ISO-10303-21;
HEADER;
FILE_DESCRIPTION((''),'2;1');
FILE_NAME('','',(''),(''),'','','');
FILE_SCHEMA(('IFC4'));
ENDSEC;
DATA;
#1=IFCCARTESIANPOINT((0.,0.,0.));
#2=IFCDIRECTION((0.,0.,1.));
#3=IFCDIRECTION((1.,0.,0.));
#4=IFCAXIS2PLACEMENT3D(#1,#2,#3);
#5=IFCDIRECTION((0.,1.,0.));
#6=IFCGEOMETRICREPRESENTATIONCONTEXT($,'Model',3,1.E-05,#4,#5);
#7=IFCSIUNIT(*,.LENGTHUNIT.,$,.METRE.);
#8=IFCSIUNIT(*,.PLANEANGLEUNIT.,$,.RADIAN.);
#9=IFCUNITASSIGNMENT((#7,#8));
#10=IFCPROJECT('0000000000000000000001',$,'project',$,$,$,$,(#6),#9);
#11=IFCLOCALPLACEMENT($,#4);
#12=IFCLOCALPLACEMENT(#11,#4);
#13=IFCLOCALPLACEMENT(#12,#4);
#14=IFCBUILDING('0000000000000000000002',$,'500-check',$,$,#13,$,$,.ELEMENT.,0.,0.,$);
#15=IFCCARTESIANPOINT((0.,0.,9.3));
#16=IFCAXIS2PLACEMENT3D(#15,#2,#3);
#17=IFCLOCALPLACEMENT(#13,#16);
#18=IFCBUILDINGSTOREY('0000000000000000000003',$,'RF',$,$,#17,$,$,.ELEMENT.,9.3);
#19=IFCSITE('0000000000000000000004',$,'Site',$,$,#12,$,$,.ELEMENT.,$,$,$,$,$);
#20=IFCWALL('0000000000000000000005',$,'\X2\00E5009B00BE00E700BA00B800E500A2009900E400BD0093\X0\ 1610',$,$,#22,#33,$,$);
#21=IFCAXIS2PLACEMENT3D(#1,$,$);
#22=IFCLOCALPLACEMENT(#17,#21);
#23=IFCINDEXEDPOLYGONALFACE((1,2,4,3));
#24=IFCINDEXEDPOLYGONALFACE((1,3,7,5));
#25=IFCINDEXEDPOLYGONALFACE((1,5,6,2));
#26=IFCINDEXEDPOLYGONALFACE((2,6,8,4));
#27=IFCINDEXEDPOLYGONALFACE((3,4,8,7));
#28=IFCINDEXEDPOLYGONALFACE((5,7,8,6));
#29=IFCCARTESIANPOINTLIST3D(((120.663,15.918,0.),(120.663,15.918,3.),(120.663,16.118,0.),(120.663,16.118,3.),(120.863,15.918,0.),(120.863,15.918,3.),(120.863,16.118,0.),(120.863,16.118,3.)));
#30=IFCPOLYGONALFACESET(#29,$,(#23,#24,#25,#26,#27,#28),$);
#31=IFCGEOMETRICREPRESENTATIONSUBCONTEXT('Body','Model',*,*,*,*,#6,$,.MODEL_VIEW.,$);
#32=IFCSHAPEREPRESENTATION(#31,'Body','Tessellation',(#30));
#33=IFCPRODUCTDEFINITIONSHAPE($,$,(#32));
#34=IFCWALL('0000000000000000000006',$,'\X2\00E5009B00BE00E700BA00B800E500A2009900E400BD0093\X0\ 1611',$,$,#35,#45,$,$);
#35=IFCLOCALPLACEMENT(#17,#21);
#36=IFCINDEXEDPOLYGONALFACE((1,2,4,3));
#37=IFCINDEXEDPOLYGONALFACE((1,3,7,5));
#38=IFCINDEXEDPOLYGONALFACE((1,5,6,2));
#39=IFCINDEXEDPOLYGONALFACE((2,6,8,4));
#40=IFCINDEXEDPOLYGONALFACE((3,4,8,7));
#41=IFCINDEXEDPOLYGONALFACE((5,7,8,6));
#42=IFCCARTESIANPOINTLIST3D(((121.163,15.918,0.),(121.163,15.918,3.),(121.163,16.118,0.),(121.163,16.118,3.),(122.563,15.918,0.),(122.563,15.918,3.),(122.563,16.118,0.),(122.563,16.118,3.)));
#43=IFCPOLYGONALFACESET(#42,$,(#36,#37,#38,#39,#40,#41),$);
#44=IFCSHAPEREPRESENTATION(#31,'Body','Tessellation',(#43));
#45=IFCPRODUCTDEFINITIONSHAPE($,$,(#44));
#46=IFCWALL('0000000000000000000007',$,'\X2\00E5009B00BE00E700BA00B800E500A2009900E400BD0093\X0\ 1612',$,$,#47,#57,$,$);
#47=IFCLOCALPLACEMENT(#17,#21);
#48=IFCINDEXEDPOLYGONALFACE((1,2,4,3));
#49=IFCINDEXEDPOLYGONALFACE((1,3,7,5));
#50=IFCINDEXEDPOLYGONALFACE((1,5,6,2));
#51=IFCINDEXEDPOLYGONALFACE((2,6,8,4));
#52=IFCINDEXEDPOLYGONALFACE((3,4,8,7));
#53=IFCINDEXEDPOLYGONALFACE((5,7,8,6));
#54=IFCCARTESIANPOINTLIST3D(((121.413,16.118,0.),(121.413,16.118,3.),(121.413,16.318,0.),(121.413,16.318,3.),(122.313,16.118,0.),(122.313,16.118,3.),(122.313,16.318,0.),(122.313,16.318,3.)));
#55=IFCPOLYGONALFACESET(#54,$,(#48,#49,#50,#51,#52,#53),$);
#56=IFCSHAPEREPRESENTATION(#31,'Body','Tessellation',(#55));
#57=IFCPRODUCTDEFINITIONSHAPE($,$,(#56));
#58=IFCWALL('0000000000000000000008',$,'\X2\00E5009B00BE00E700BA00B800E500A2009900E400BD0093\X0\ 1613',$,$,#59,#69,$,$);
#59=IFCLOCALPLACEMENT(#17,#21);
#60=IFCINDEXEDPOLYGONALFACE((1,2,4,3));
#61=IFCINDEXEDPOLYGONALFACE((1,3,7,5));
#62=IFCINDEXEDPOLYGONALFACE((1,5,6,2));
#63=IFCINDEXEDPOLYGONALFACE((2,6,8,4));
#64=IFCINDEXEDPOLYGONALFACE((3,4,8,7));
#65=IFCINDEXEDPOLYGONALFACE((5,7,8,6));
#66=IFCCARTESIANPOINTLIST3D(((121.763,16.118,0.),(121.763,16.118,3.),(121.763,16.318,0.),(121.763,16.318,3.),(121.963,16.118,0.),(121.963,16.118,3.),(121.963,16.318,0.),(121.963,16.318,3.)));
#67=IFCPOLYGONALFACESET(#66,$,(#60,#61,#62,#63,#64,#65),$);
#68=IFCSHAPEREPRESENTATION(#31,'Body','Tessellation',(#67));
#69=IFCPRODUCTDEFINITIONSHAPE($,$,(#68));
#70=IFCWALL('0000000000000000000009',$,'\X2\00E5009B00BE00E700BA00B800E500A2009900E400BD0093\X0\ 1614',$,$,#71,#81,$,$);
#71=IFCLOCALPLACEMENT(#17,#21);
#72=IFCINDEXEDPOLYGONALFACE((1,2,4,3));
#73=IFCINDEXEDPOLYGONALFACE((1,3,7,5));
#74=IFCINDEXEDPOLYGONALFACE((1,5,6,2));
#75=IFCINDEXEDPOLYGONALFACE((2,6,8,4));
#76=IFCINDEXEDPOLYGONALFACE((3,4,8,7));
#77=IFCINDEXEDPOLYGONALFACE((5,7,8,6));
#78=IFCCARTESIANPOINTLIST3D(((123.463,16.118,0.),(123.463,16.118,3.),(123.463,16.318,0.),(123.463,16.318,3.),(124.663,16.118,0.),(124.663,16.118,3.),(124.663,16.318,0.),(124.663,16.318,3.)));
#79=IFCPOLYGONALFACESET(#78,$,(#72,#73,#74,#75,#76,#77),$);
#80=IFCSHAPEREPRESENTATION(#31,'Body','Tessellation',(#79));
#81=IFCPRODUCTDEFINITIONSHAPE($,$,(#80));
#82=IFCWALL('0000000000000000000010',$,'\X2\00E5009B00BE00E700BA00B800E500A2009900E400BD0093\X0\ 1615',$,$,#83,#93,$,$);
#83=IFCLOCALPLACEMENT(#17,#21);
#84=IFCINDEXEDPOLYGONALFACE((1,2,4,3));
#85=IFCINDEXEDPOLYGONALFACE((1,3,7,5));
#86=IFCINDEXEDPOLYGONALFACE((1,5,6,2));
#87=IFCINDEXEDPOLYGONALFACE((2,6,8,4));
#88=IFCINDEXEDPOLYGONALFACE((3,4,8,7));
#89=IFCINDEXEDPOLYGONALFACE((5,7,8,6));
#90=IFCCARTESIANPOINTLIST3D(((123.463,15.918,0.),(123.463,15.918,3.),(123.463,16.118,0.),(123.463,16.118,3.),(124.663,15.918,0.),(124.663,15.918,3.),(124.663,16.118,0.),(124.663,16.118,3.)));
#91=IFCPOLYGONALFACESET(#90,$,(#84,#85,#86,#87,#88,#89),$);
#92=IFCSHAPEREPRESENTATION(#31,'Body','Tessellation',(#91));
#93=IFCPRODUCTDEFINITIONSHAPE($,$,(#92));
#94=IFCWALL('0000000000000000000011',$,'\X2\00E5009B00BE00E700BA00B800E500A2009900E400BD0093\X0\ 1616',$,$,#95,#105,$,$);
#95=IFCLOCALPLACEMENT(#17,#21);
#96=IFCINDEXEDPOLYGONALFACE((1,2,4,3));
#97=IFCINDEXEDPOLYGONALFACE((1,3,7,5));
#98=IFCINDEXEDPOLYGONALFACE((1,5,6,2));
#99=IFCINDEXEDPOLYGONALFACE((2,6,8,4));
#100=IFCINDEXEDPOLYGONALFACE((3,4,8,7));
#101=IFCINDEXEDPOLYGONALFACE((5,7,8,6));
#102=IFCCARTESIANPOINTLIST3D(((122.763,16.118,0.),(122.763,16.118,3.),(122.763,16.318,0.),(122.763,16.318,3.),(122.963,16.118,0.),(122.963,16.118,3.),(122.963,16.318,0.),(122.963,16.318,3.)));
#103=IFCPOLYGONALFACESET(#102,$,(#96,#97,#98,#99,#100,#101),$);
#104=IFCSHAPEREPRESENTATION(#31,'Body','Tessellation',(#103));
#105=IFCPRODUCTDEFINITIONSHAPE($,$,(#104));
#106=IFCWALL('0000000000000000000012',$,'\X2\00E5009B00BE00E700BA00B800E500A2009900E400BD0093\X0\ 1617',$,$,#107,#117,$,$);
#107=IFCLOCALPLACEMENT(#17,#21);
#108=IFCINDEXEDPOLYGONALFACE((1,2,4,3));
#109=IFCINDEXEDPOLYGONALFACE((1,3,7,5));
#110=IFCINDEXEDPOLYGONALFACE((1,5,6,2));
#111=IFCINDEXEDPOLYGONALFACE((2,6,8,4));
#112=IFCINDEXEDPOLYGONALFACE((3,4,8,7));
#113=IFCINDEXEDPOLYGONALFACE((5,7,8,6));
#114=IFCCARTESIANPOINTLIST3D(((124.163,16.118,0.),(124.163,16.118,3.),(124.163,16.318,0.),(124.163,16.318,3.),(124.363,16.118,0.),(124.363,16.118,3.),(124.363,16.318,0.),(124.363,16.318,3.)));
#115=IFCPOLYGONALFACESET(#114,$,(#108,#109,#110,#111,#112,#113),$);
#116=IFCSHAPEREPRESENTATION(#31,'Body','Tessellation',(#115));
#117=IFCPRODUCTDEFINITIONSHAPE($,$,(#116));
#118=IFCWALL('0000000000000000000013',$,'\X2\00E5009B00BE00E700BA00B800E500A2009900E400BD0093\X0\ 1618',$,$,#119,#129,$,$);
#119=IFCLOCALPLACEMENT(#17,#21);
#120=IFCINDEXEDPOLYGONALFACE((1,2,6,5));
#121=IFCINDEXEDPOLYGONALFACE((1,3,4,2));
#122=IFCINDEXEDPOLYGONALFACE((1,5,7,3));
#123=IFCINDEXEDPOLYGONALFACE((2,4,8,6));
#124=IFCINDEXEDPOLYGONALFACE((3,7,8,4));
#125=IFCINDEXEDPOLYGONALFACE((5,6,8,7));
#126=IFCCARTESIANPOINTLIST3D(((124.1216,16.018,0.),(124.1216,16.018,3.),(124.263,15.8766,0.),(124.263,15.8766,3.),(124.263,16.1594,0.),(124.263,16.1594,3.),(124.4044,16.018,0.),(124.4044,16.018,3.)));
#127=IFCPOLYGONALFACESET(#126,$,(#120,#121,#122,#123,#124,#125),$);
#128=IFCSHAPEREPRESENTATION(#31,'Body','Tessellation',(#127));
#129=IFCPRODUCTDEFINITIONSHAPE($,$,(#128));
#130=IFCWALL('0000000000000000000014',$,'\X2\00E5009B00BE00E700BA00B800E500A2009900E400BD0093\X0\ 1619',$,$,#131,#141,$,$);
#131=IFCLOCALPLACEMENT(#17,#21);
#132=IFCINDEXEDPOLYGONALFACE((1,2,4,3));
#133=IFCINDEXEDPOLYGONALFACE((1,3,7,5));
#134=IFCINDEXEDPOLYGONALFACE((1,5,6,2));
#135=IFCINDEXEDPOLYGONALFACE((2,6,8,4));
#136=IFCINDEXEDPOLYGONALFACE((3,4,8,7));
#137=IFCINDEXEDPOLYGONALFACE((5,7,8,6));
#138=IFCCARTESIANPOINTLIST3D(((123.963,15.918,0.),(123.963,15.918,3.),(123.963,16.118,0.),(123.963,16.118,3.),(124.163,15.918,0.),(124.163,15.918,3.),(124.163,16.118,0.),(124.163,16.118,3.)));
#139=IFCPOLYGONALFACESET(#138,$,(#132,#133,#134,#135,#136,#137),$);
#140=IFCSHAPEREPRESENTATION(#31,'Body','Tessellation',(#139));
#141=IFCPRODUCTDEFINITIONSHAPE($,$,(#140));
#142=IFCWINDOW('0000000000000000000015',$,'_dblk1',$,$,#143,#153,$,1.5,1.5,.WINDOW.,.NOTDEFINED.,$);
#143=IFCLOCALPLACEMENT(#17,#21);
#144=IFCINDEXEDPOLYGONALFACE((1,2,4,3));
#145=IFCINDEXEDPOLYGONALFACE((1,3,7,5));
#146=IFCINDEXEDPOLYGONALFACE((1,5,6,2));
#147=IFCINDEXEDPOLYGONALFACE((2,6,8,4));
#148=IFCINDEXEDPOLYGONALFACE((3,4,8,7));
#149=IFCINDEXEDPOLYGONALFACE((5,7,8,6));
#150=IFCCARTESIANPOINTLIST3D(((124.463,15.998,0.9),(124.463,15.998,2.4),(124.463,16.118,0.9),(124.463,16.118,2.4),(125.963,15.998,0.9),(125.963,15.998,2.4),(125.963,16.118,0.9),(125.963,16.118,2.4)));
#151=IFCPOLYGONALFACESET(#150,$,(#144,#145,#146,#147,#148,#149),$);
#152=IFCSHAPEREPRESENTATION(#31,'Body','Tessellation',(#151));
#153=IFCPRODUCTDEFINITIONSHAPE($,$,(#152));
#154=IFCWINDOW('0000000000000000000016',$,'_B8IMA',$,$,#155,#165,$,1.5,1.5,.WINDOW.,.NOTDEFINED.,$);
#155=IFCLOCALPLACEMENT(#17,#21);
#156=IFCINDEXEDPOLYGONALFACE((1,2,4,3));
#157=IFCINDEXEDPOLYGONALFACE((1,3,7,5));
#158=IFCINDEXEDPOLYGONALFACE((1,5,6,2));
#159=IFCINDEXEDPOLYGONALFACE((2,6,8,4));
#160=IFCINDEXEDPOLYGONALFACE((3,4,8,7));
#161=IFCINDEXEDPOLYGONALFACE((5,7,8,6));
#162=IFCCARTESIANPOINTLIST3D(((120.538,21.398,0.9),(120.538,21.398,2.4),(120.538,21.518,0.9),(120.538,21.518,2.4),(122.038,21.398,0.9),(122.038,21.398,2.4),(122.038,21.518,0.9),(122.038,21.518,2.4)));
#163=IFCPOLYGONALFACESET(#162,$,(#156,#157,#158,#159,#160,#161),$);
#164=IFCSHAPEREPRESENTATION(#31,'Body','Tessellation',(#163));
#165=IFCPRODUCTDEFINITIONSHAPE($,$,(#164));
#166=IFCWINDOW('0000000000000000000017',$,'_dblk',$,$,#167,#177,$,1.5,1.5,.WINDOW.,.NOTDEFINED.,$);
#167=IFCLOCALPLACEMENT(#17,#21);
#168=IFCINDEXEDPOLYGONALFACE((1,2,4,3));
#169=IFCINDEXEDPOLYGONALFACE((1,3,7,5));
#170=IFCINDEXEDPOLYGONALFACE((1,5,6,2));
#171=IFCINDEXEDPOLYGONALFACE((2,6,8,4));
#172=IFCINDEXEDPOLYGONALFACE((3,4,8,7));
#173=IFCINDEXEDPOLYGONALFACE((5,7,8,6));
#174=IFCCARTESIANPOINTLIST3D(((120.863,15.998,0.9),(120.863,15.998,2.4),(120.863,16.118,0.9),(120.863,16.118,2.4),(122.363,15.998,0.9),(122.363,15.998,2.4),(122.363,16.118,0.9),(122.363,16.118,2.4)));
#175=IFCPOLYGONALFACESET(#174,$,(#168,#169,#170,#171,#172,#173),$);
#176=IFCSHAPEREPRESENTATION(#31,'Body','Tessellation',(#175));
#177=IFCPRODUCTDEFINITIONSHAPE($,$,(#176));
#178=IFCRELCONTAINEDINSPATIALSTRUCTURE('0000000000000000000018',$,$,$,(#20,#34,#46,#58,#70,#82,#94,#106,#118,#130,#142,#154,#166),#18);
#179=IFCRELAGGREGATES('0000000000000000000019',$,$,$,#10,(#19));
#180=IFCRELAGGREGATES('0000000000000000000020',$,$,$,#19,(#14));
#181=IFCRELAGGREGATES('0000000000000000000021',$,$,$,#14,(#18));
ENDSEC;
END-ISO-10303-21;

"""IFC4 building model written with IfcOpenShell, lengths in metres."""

from ifc_helpers import new_model, si_unit, direction, frame, frame_2d, origin_with_axes, place, context, subcontext, project, spatial, rectangle, extrude, element, save


model = new_model("IFC4")

# Units and contexts
model_context = context("Model", 3, precision=1e-05, world=origin_with_axes(), true_north=direction((0.0, 1.0, 0.0)))
body_context = subcontext(model_context, "Body", "Model", "MODEL_VIEW")
ifc_project = project(units=[si_unit("LENGTHUNIT", "METRE"), si_unit("PLANEANGLEUNIT", "RADIAN")], contexts=[model_context])

# Site, building, storey
placement = place(None, origin_with_axes())
site_placement = place(placement, origin_with_axes())
site = spatial("IfcSite", under=ifc_project, at=site_placement, Name="Site", CompositionType="ELEMENT")
building_placement = place(site_placement, origin_with_axes())
building = spatial("IfcBuilding", under=site, at=building_placement, Name="500-check", CompositionType="ELEMENT", ElevationOfRefHeight=0.0, ElevationOfTerrain=0.0)
storey_placement = place(building_placement, frame((0.0, 0.0, 9.3), z_axis=(0.0, 0.0, 1.0), x_axis=(1.0, 0.0, 0.0)))
storey = spatial("IfcBuildingStorey", under=building, at=storey_placement, Name="RF", CompositionType="ELEMENT", Elevation=9.3)

# Walls
wall_1_placement = place(storey_placement, frame((120.763, 16.018, 0.0), z_axis=(0.0, 0.0, 1.0), x_axis=(1.0, 0.0, 0.0)))
element("IfcWall", 1, at=wall_1_placement, inside=storey, Name="å\u009b¾çº¸å¢\u0099ä½\u0093 1610", context=body_context, shape_type="SweptSolid", body=[
    extrude(rectangle(XDim=0.2, YDim=0.2, at=frame_2d((0.0, 0.0), x_axis=(1.0, 0.0, 0.0))), frame((0.0, 0.0, 0.0), z_axis=(0.0, 0.0, 1.0)), (0.0, 0.0, 1.0), 3.0),
])
wall_2_placement = place(storey_placement, frame((121.863, 16.018, 0.0), z_axis=(0.0, 0.0, 1.0), x_axis=(-1.0, 0.0, 0.0)))
element("IfcWall", 2, at=wall_2_placement, inside=storey, Name="å\u009b¾çº¸å¢\u0099ä½\u0093 1611", context=body_context, shape_type="SweptSolid", body=[
    extrude(rectangle(XDim=1.4, YDim=0.2, at=frame_2d((0.0, 0.0), x_axis=(1.0, 0.0, 0.0))), frame((0.0, 0.0, 0.0), z_axis=(0.0, 0.0, 1.0)), (0.0, 0.0, 1.0), 3.0),
])
wall_3_placement = place(storey_placement, frame((121.863, 16.218, 0.0), z_axis=(0.0, 0.0, 1.0), x_axis=(-1.0, 0.0, 0.0)))
element("IfcWall", 3, at=wall_3_placement, inside=storey, Name="å\u009b¾çº¸å¢\u0099ä½\u0093 1612", context=body_context, shape_type="SweptSolid", body=[
    extrude(rectangle(XDim=0.9, YDim=0.2, at=frame_2d((0.0, 0.0), x_axis=(1.0, 0.0, 0.0))), frame((0.0, 0.0, 0.0), z_axis=(0.0, 0.0, 1.0)), (0.0, 0.0, 1.0), 3.0),
])
wall_4_placement = place(storey_placement, frame((121.863, 16.218, 0.0), z_axis=(0.0, 0.0, 1.0), x_axis=(0.0, -1.0, 0.0)))
element("IfcWall", 4, at=wall_4_placement, inside=storey, Name="å\u009b¾çº¸å¢\u0099ä½\u0093 1613", context=body_context, shape_type="SweptSolid", body=[
    extrude(rectangle(XDim=0.2, YDim=0.2, at=frame_2d((0.0, 0.0), x_axis=(1.0, 0.0, 0.0))), frame((0.0, 0.0, 0.0), z_axis=(0.0, 0.0, 1.0)), (0.0, 0.0, 1.0), 3.0),
])
for number, where, z_axis, x_axis, name in (
    (5, (124.063, 16.218, 0.0), (0.0, 0.0, 1.0), (-1.0, 0.0, 0.0), "å\u009b¾çº¸å¢\u0099ä½\u0093 1614"),
    (6, (124.063, 16.018, 0.0), (0.0, 0.0, 1.0), (-1.0, 0.0, 0.0), "å\u009b¾çº¸å¢\u0099ä½\u0093 1615"),
):
    element("IfcWall", number, at=place(storey_placement, frame(where, z_axis=z_axis, x_axis=x_axis)), inside=storey, Name=name, context=body_context, shape_type="SweptSolid", body=[
        extrude(rectangle(XDim=1.2, YDim=0.2, at=frame_2d((0.0, 0.0), x_axis=(1.0, 0.0, 0.0))), frame((0.0, 0.0, 0.0), z_axis=(0.0, 0.0, 1.0)), (0.0, 0.0, 1.0), 3.0),
    ])
for number, where, z_axis, x_axis, name in (
    (7, (122.863, 16.218, 0.0), (0.0, 0.0, 1.0), (0.0, -1.0, 0.0), "å\u009b¾çº¸å¢\u0099ä½\u0093 1616"),
    (8, (124.263, 16.218, 0.0), (0.0, 0.0, 1.0), (0.0, -1.0, 0.0), "å\u009b¾çº¸å¢\u0099ä½\u0093 1617"),
    (9, (124.263, 16.018, 0.0), (0.0, 0.0, 1.0), (-0.707107, -0.707107, 0.0), "å\u009b¾çº¸å¢\u0099ä½\u0093 1618"),
    (10, (124.063, 16.018, 0.0), (0.0, 0.0, 1.0), (1.0, 0.0, 0.0), "å\u009b¾çº¸å¢\u0099ä½\u0093 1619"),
):
    element("IfcWall", number, at=place(storey_placement, frame(where, z_axis=z_axis, x_axis=x_axis)), inside=storey, Name=name, context=body_context, shape_type="SweptSolid", body=[
        extrude(rectangle(XDim=0.2, YDim=0.2, at=frame_2d((0.0, 0.0), x_axis=(1.0, 0.0, 0.0))), frame((0.0, 0.0, 0.0), z_axis=(0.0, 0.0, 1.0)), (0.0, 0.0, 1.0), 3.0),
    ])

# Windows
for number, where, z_axis, x_axis, name in (
    (11, (125.213, 16.058, 0.9), (0.0, 0.0, 1.0), (1.0, 0.0, 0.0), "_dblk1"),
    (12, (121.288, 21.458, 0.9), (0.0, 0.0, 1.0), (1.0, 0.0, 0.0), "_B8IMA"),
    (13, (121.613, 16.058, 0.9), (0.0, 0.0, 1.0), (1.0, 0.0, 0.0), "_dblk"),
):
    element("IfcWindow", number, at=place(storey_placement, frame(where, z_axis=z_axis, x_axis=x_axis)), inside=storey, Name=name, OverallHeight=1.5, OverallWidth=1.5, PartitioningType="NOTDEFINED", PredefinedType="WINDOW", context=body_context, shape_type="SweptSolid", body=[
        extrude(rectangle(XDim=1.5, YDim=0.12, at=frame_2d((0.0, 0.0), x_axis=(1.0, 0.0, 0.0))), frame((0.0, 0.0, 0.0), z_axis=(0.0, 0.0, 1.0)), (0.0, 0.0, 1.0), 1.5),
    ])

save(model, "model.ifc")
